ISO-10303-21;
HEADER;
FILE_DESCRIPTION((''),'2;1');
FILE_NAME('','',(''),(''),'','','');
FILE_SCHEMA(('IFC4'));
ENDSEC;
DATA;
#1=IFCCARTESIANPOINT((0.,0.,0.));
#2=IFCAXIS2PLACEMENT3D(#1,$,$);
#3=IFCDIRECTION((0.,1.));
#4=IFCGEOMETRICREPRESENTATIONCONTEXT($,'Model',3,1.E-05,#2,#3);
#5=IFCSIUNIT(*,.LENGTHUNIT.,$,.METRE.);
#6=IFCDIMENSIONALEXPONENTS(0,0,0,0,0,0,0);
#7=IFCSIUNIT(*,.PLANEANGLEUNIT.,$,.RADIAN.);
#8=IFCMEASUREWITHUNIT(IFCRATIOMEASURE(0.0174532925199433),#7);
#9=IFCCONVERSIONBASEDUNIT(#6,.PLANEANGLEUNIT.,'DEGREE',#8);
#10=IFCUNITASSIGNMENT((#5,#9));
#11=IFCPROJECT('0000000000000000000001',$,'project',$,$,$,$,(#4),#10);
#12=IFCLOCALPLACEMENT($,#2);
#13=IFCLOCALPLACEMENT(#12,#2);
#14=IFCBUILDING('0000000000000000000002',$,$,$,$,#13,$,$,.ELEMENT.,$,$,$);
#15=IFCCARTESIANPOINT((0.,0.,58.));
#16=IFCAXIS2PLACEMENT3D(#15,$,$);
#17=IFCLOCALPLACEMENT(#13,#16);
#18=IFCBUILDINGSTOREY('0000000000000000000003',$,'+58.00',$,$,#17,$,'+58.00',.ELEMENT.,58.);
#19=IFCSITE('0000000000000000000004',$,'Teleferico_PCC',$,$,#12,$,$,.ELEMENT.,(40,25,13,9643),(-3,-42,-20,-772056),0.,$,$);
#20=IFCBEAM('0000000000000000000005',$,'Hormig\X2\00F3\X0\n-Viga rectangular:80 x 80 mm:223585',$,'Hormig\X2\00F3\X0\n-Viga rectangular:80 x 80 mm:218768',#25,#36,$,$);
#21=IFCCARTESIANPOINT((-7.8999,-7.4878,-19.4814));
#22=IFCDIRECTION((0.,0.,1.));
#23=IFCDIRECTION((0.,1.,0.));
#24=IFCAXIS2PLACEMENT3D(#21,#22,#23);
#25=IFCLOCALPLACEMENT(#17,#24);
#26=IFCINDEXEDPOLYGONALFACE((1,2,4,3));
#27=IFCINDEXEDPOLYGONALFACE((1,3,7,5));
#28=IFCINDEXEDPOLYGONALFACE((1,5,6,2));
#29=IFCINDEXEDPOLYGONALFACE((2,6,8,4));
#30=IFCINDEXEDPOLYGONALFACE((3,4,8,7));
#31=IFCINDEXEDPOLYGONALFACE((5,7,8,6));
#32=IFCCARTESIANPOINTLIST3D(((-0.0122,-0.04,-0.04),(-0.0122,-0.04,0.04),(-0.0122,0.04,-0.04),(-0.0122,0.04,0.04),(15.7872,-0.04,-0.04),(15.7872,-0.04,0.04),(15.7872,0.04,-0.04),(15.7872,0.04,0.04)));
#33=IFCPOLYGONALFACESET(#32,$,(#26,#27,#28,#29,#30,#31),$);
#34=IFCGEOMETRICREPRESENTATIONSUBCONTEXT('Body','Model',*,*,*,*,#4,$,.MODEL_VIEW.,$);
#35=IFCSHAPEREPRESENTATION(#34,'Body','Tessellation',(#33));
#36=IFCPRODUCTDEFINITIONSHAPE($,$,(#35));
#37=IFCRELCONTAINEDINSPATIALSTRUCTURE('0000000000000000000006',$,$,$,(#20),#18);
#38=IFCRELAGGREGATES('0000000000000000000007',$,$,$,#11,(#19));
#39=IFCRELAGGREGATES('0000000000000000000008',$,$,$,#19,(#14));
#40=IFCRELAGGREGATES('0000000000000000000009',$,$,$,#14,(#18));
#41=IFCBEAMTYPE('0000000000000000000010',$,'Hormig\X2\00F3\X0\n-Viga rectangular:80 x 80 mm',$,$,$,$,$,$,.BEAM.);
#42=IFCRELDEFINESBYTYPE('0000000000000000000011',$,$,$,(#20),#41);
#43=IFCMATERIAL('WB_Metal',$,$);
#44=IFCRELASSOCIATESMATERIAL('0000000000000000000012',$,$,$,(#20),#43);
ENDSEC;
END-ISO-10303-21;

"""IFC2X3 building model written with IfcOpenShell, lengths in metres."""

from ifc_helpers import new_model, entity, si_unit, converted_unit, direction, frame, frame_2d, origin, place, context, subcontext, project, spatial, rectangle, extrude, material, type_object, element, save


model = new_model("IFC2X3")

# Units and contexts
model_context = context("Model", 3, precision=1e-05, world=origin(), true_north=direction((0.0, 1.0)))
body_context = subcontext(model_context, "Body", "Model", "MODEL_VIEW")
ifc_project = project(units=[si_unit("LENGTHUNIT", "METRE"), converted_unit("PLANEANGLEUNIT", "DEGREE", entity("IfcRatioMeasure", 0.0174532925199433), si_unit("PLANEANGLEUNIT", "RADIAN"), dimensions=[0, 0, 0, 0, 0, 0, 0])], contexts=[model_context])

# Site, building, storey
site_placement = place(None, origin())
site = spatial("IfcSite", under=ifc_project, at=site_placement, Name="Teleferico_PCC", CompositionType="ELEMENT", RefLatitude=(40, 25, 13, 9643), RefLongitude=(-3, -42, -20, -772056), RefElevation=0.0)
building_placement = place(site_placement, origin())
building = spatial("IfcBuilding", under=site, at=building_placement, CompositionType="ELEMENT")
storey_placement = place(building_placement, frame((0.0, 0.0, 58.0)))
storey = spatial("IfcBuildingStorey", under=building, at=storey_placement, Name="+58.00", LongName="+58.00", CompositionType="ELEMENT", Elevation=58.0)

# Beam
ifc_material = material(Name="WB_Metal")
beam_type_1 = type_object("IfcBeamType", Name="Hormigón-Viga rectangular:80 x 80 mm", PredefinedType="BEAM")
beam_1_placement = place(storey_placement, frame((-7.8999, -7.4878, -19.4814), z_axis=(0.0, 0.0, 1.0), x_axis=(0.0, 1.0, 0.0)))
element("IfcBeam", 1, at=beam_1_placement, inside=storey, type_object=beam_type_1, material=ifc_material, Name="Hormigón-Viga rectangular:80 x 80 mm:223585", ObjectType="Hormigón-Viga rectangular:80 x 80 mm:218768", context=body_context, shape_type="SweptSolid", body=[
    extrude(rectangle(XDim=0.08, YDim=0.08, at=frame_2d((0.0, 0.0), x_axis=(1.0, 0.0))), frame((-0.0122, 0.0, 0.0), z_axis=(1.0, 0.0, 0.0), x_axis=(0.0, 0.0, -1.0)), (0.0, 0.0, 1.0), 15.7994),
])

save(model, "model.ifc")
